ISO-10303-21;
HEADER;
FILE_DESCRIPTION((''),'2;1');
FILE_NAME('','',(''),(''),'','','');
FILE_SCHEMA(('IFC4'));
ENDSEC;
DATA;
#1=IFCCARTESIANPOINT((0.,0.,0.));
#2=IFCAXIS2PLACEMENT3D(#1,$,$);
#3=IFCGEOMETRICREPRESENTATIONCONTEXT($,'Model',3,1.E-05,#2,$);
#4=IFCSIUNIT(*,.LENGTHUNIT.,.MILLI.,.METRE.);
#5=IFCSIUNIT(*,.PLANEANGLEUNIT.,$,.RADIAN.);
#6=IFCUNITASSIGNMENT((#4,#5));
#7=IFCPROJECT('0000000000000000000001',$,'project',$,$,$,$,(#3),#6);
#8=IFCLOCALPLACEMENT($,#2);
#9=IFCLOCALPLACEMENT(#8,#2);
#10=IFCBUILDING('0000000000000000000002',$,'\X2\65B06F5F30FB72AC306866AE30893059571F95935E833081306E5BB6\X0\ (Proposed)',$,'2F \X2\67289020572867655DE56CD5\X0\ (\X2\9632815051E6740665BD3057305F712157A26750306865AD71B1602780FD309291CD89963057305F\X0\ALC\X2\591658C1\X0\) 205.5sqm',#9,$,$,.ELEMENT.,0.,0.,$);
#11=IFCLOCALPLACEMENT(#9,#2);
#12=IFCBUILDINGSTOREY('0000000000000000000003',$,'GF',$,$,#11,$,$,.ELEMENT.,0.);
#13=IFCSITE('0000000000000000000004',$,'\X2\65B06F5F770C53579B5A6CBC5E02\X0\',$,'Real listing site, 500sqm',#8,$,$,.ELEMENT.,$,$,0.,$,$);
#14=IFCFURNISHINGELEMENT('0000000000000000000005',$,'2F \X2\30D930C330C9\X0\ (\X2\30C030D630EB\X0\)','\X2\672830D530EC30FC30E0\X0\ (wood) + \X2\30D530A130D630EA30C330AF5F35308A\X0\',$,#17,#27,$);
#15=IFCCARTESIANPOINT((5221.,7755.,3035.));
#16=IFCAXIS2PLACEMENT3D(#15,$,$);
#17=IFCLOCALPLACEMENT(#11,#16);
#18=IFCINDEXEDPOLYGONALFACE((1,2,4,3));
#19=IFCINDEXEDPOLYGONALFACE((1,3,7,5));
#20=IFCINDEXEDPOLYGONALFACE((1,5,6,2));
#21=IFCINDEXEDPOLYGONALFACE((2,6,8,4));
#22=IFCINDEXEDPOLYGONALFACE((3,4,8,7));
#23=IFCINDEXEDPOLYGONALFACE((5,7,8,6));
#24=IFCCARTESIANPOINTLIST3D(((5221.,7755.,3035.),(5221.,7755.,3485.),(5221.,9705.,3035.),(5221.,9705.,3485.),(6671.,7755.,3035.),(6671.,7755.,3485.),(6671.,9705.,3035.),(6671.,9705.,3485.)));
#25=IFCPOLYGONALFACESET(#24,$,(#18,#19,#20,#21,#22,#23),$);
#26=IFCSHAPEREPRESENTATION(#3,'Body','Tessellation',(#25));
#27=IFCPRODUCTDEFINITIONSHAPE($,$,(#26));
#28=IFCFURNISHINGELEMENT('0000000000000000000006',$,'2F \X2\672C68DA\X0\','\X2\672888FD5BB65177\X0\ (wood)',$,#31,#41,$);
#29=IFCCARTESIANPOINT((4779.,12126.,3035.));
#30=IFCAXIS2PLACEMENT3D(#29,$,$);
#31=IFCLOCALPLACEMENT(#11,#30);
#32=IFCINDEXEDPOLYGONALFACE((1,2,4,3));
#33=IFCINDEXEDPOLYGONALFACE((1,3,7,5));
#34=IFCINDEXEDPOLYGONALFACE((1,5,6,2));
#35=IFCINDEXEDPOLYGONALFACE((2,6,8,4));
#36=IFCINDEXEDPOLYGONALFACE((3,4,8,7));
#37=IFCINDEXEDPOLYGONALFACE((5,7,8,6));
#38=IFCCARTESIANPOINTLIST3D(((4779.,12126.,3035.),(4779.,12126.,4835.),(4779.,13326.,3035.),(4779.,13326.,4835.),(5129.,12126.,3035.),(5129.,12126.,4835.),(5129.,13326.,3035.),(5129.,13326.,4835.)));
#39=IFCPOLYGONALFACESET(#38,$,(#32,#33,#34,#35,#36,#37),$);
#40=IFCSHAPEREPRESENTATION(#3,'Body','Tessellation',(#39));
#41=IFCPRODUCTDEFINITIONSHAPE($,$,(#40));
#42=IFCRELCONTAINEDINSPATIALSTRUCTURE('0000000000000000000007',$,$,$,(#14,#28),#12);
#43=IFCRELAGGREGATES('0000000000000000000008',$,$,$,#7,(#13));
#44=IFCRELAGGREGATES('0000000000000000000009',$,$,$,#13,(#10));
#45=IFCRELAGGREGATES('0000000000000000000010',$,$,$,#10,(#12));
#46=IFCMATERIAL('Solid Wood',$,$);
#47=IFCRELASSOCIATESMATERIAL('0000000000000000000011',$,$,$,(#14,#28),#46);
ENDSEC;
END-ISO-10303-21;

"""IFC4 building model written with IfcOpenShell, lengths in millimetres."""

from ifc_helpers import new_model, si_unit, frame, frame_2d, origin, place, context, project, spatial, rectangle, extrude, material, element, save


model = new_model("IFC4")

# Units and contexts
model_context = context("Model", 3, precision=1e-05, world=origin())
ifc_project = project(units=[si_unit("LENGTHUNIT", "METRE", prefix="MILLI"), si_unit("PLANEANGLEUNIT", "RADIAN")], contexts=[model_context])

# Site, building, storey
site_placement = place(None, origin())
site = spatial("IfcSite", under=ifc_project, at=site_placement, Name="新潟県南魚沼市", ObjectType="Real listing site, 500sqm", CompositionType="ELEMENT", RefElevation=0.0)
building_placement = place(site_placement, origin())
building = spatial("IfcBuilding", under=site, at=building_placement, Name="新潟・犬と暮らす土間広めの家 (Proposed)", ObjectType="2F 木造在来工法 (防腐処理施した無垢材と断熱性能を重視したALC外壁) 205.5sqm", CompositionType="ELEMENT", ElevationOfRefHeight=0.0, ElevationOfTerrain=0.0)
storey_placement = place(building_placement, origin())
storey = spatial("IfcBuildingStorey", under=building, at=storey_placement, Name="GF", CompositionType="ELEMENT", Elevation=0.0)

# Shared definitions
ifc_material_1 = material(Name="Solid Wood")

# Furnishing elements
furnishing_1_placement = place(storey_placement, frame((5221.0, 7755.0, 3035.0)))
element("IfcFurnishingElement", 1, at=furnishing_1_placement, inside=storey, material=ifc_material_1, Name="2F ベッド (ダブル)", Description="木フレーム (wood) + ファブリック張り", context=model_context, shape_type="SweptSolid", body=[
    extrude(rectangle(XDim=1450.0, YDim=1950.0, at=frame_2d((725.0, 975.0))), frame((5221.0, 7755.0, 3035.0)), (0.0, 0.0, 1.0), 450.0),
])
furnishing_2_placement = place(storey_placement, frame((4779.0, 12126.0, 3035.0)))
element("IfcFurnishingElement", 2, at=furnishing_2_placement, inside=storey, material=ifc_material_1, Name="2F 本棚", Description="木製家具 (wood)", context=model_context, shape_type="SweptSolid", body=[
    extrude(rectangle(XDim=350.0, YDim=1200.0, at=frame_2d((175.0, 600.0))), frame((4779.0, 12126.0, 3035.0)), (0.0, 0.0, 1.0), 1800.0),
])

save(model, "model.ifc")
